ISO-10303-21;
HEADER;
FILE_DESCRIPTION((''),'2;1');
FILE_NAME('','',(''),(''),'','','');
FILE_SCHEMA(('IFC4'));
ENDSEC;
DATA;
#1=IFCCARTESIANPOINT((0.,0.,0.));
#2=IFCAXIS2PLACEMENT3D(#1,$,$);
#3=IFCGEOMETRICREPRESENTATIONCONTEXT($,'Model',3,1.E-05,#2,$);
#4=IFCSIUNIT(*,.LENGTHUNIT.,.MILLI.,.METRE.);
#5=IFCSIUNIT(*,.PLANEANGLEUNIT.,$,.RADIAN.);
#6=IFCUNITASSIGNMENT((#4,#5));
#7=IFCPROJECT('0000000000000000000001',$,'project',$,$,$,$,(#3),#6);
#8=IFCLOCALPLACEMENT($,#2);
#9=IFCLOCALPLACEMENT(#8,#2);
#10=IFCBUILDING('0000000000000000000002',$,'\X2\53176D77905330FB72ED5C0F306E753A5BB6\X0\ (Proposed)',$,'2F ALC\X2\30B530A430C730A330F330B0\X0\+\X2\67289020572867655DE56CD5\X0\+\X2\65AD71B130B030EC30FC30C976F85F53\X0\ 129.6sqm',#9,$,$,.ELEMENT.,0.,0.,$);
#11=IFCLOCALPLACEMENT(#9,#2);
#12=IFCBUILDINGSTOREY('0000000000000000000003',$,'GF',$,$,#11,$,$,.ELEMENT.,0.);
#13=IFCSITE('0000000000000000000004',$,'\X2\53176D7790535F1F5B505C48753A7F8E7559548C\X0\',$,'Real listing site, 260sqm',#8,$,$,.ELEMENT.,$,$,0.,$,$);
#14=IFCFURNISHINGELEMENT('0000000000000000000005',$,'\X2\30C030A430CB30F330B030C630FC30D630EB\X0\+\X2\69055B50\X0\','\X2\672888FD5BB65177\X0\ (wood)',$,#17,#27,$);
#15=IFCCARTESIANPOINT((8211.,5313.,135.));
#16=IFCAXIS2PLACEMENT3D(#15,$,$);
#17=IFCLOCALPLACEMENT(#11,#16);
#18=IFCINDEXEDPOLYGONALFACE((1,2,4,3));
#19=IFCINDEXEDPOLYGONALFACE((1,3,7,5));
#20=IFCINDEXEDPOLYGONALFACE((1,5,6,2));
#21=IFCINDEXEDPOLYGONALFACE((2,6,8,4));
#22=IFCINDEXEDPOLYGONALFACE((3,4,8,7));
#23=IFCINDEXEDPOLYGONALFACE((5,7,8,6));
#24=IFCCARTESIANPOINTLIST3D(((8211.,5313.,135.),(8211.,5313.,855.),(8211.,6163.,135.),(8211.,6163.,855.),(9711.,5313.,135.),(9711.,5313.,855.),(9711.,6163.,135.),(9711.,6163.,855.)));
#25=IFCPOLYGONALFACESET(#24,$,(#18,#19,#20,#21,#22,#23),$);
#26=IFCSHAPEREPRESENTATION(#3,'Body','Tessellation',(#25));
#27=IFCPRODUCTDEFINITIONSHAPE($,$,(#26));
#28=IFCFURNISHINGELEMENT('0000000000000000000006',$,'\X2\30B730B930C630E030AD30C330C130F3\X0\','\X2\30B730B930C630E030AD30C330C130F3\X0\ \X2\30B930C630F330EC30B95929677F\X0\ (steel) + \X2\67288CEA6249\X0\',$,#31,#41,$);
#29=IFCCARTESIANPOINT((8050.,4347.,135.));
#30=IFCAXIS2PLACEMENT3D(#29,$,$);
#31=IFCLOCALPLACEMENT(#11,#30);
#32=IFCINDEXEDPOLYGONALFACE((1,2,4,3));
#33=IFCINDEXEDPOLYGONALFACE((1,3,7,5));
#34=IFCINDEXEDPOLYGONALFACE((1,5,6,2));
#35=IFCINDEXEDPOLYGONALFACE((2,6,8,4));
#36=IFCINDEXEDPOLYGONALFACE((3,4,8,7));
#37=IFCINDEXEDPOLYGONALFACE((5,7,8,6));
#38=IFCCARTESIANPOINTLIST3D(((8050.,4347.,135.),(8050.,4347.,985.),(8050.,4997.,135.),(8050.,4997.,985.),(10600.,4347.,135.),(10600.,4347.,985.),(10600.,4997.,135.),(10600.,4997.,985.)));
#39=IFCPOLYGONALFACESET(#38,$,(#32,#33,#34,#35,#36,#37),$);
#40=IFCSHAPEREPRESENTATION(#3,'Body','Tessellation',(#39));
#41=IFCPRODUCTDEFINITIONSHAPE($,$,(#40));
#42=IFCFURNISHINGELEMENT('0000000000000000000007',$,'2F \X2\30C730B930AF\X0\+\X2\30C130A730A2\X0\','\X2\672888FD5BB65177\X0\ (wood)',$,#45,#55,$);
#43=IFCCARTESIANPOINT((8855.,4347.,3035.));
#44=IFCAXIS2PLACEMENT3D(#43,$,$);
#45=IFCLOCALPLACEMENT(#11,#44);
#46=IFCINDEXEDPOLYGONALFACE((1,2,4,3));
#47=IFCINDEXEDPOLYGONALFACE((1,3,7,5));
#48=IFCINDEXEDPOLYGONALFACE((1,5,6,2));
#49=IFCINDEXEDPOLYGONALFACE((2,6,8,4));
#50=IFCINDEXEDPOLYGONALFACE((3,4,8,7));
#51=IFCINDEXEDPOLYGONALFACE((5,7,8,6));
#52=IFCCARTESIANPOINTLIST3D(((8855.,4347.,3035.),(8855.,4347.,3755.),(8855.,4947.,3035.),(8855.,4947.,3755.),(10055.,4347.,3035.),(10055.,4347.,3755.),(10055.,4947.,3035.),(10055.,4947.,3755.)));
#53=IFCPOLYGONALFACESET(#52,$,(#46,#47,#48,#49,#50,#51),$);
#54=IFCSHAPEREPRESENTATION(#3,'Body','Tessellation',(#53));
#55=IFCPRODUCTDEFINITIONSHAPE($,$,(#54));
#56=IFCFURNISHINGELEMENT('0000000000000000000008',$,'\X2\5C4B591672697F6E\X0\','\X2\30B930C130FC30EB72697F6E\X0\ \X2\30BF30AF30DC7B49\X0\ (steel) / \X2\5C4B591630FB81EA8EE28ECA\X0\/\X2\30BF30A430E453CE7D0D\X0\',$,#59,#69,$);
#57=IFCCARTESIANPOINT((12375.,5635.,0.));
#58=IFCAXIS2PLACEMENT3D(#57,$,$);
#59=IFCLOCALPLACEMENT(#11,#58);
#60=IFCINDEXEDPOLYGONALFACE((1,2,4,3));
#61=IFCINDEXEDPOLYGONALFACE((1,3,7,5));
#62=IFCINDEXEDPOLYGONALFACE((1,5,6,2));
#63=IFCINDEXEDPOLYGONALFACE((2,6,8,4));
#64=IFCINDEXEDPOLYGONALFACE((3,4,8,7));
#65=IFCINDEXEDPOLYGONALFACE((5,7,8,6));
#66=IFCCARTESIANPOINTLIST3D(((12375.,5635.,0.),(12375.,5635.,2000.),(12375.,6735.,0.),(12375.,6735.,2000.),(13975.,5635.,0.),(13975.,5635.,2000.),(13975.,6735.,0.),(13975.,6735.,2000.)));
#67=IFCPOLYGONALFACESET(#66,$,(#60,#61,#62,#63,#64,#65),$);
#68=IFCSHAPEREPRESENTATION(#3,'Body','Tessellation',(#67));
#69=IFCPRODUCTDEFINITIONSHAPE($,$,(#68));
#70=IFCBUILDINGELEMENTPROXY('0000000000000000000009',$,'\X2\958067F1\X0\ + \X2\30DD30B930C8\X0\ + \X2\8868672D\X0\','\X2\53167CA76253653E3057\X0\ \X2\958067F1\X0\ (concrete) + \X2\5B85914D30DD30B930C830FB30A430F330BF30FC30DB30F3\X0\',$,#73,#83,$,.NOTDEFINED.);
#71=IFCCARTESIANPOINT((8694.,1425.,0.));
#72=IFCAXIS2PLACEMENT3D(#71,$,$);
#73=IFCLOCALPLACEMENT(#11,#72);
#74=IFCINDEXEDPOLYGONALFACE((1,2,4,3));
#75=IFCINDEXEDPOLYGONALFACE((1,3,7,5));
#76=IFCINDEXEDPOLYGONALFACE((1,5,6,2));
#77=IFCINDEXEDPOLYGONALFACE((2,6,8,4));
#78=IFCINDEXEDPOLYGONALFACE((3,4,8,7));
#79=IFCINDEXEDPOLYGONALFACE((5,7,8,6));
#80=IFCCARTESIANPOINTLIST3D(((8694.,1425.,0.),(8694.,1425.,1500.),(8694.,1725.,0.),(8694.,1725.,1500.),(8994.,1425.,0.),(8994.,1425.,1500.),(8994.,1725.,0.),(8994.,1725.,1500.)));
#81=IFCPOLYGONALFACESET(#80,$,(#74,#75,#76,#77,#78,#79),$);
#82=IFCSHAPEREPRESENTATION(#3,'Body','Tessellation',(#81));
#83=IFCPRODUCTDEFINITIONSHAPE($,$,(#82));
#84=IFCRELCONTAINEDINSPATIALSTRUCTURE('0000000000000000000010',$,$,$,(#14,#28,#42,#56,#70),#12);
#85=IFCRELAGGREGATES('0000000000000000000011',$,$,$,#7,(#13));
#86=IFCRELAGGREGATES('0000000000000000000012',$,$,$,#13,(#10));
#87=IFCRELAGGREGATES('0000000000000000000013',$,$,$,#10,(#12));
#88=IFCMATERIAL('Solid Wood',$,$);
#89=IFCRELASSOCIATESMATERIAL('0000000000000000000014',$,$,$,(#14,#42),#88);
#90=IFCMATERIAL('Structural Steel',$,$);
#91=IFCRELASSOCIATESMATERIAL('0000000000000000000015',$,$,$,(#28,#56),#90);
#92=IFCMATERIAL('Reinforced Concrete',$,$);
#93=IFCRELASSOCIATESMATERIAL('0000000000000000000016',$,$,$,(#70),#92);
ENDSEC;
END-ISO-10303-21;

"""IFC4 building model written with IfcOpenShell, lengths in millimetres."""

from ifc_helpers import new_model, si_unit, frame, frame_2d, origin, place, context, project, spatial, rectangle, extrude, material, element, save


model = new_model("IFC4")

# Units and contexts
model_context = context("Model", 3, precision=1e-05, world=origin())
ifc_project = project(units=[si_unit("LENGTHUNIT", "METRE", prefix="MILLI"), si_unit("PLANEANGLEUNIT", "RADIAN")], contexts=[model_context])

# Site, building, storey
site_placement = place(None, origin())
site = spatial("IfcSite", under=ifc_project, at=site_placement, Name="北海道弟子屈町美留和", ObjectType="Real listing site, 260sqm", CompositionType="ELEMENT", RefElevation=0.0)
building_placement = place(site_placement, origin())
building = spatial("IfcBuilding", under=site, at=building_placement, Name="北海道・狭小の町家 (Proposed)", ObjectType="2F ALCサイディング+木造在来工法+断熱グレード相当 129.6sqm", CompositionType="ELEMENT", ElevationOfRefHeight=0.0, ElevationOfTerrain=0.0)
storey_placement = place(building_placement, origin())
storey = spatial("IfcBuildingStorey", under=building, at=storey_placement, Name="GF", CompositionType="ELEMENT", Elevation=0.0)

# Shared definitions
ifc_material_1 = material(Name="Solid Wood")

# Shared definitions
ifc_material_2 = material(Name="Reinforced Concrete")

# Shared definitions
ifc_material_3 = material(Name="Structural Steel")

# Furnishing elements
furnishing_1_placement = place(storey_placement, frame((8211.0, 5313.0, 135.0)))
element("IfcFurnishingElement", 1, at=furnishing_1_placement, inside=storey, material=ifc_material_1, Name="ダイニングテーブル+椅子", Description="木製家具 (wood)", context=model_context, shape_type="SweptSolid", body=[
    extrude(rectangle(XDim=1500.0, YDim=850.0, at=frame_2d((750.0, 425.0))), frame((8211.0, 5313.0, 135.0)), (0.0, 0.0, 1.0), 720.0),
])
furnishing_2_placement = place(storey_placement, frame((8050.0, 4347.0, 135.0)))
element("IfcFurnishingElement", 2, at=furnishing_2_placement, inside=storey, material=ifc_material_3, Name="システムキッチン", Description="システムキッチン ステンレス天板 (steel) + 木質扉", context=model_context, shape_type="SweptSolid", body=[
    extrude(rectangle(XDim=2550.0, YDim=650.0, at=frame_2d((1275.0, 325.0))), frame((8050.0, 4347.0, 135.0)), (0.0, 0.0, 1.0), 850.0),
])
furnishing_3_placement = place(storey_placement, frame((8855.0, 4347.0, 3035.0)))
element("IfcFurnishingElement", 3, at=furnishing_3_placement, inside=storey, material=ifc_material_1, Name="2F デスク+チェア", Description="木製家具 (wood)", context=model_context, shape_type="SweptSolid", body=[
    extrude(rectangle(XDim=1200.0, YDim=600.0, at=frame_2d((600.0, 300.0))), frame((8855.0, 4347.0, 3035.0)), (0.0, 0.0, 1.0), 720.0),
])
furnishing_4_placement = place(storey_placement, frame((12375.0, 5635.0, 0.0)))
element("IfcFurnishingElement", 4, at=furnishing_4_placement, inside=storey, material=ifc_material_3, Name="屋外物置", Description="スチール物置 タクボ等 (steel) / 屋外・自転車/タイヤ収納", context=model_context, shape_type="SweptSolid", body=[
    extrude(rectangle(XDim=1600.0, YDim=1100.0, at=frame_2d((800.0, 550.0))), frame((12375.0, 5635.0, 0.0)), (0.0, 0.0, 1.0), 2000.0),
])

# Building element proxy
proxy_placement = place(storey_placement, frame((8694.0, 1425.0, 0.0)))
element("IfcBuildingElementProxy", 5, at=proxy_placement, inside=storey, material=ifc_material_2, Name="門柱 + ポスト + 表札", Description="化粧打放し 門柱 (concrete) + 宅配ポスト・インターホン", PredefinedType="NOTDEFINED", context=model_context, shape_type="SweptSolid", body=[
    extrude(rectangle(XDim=300.0, YDim=300.0, at=frame_2d((150.0, 150.0))), frame((8694.0, 1425.0, 0.0)), (0.0, 0.0, 1.0), 1500.0),
])

save(model, "model.ifc")
